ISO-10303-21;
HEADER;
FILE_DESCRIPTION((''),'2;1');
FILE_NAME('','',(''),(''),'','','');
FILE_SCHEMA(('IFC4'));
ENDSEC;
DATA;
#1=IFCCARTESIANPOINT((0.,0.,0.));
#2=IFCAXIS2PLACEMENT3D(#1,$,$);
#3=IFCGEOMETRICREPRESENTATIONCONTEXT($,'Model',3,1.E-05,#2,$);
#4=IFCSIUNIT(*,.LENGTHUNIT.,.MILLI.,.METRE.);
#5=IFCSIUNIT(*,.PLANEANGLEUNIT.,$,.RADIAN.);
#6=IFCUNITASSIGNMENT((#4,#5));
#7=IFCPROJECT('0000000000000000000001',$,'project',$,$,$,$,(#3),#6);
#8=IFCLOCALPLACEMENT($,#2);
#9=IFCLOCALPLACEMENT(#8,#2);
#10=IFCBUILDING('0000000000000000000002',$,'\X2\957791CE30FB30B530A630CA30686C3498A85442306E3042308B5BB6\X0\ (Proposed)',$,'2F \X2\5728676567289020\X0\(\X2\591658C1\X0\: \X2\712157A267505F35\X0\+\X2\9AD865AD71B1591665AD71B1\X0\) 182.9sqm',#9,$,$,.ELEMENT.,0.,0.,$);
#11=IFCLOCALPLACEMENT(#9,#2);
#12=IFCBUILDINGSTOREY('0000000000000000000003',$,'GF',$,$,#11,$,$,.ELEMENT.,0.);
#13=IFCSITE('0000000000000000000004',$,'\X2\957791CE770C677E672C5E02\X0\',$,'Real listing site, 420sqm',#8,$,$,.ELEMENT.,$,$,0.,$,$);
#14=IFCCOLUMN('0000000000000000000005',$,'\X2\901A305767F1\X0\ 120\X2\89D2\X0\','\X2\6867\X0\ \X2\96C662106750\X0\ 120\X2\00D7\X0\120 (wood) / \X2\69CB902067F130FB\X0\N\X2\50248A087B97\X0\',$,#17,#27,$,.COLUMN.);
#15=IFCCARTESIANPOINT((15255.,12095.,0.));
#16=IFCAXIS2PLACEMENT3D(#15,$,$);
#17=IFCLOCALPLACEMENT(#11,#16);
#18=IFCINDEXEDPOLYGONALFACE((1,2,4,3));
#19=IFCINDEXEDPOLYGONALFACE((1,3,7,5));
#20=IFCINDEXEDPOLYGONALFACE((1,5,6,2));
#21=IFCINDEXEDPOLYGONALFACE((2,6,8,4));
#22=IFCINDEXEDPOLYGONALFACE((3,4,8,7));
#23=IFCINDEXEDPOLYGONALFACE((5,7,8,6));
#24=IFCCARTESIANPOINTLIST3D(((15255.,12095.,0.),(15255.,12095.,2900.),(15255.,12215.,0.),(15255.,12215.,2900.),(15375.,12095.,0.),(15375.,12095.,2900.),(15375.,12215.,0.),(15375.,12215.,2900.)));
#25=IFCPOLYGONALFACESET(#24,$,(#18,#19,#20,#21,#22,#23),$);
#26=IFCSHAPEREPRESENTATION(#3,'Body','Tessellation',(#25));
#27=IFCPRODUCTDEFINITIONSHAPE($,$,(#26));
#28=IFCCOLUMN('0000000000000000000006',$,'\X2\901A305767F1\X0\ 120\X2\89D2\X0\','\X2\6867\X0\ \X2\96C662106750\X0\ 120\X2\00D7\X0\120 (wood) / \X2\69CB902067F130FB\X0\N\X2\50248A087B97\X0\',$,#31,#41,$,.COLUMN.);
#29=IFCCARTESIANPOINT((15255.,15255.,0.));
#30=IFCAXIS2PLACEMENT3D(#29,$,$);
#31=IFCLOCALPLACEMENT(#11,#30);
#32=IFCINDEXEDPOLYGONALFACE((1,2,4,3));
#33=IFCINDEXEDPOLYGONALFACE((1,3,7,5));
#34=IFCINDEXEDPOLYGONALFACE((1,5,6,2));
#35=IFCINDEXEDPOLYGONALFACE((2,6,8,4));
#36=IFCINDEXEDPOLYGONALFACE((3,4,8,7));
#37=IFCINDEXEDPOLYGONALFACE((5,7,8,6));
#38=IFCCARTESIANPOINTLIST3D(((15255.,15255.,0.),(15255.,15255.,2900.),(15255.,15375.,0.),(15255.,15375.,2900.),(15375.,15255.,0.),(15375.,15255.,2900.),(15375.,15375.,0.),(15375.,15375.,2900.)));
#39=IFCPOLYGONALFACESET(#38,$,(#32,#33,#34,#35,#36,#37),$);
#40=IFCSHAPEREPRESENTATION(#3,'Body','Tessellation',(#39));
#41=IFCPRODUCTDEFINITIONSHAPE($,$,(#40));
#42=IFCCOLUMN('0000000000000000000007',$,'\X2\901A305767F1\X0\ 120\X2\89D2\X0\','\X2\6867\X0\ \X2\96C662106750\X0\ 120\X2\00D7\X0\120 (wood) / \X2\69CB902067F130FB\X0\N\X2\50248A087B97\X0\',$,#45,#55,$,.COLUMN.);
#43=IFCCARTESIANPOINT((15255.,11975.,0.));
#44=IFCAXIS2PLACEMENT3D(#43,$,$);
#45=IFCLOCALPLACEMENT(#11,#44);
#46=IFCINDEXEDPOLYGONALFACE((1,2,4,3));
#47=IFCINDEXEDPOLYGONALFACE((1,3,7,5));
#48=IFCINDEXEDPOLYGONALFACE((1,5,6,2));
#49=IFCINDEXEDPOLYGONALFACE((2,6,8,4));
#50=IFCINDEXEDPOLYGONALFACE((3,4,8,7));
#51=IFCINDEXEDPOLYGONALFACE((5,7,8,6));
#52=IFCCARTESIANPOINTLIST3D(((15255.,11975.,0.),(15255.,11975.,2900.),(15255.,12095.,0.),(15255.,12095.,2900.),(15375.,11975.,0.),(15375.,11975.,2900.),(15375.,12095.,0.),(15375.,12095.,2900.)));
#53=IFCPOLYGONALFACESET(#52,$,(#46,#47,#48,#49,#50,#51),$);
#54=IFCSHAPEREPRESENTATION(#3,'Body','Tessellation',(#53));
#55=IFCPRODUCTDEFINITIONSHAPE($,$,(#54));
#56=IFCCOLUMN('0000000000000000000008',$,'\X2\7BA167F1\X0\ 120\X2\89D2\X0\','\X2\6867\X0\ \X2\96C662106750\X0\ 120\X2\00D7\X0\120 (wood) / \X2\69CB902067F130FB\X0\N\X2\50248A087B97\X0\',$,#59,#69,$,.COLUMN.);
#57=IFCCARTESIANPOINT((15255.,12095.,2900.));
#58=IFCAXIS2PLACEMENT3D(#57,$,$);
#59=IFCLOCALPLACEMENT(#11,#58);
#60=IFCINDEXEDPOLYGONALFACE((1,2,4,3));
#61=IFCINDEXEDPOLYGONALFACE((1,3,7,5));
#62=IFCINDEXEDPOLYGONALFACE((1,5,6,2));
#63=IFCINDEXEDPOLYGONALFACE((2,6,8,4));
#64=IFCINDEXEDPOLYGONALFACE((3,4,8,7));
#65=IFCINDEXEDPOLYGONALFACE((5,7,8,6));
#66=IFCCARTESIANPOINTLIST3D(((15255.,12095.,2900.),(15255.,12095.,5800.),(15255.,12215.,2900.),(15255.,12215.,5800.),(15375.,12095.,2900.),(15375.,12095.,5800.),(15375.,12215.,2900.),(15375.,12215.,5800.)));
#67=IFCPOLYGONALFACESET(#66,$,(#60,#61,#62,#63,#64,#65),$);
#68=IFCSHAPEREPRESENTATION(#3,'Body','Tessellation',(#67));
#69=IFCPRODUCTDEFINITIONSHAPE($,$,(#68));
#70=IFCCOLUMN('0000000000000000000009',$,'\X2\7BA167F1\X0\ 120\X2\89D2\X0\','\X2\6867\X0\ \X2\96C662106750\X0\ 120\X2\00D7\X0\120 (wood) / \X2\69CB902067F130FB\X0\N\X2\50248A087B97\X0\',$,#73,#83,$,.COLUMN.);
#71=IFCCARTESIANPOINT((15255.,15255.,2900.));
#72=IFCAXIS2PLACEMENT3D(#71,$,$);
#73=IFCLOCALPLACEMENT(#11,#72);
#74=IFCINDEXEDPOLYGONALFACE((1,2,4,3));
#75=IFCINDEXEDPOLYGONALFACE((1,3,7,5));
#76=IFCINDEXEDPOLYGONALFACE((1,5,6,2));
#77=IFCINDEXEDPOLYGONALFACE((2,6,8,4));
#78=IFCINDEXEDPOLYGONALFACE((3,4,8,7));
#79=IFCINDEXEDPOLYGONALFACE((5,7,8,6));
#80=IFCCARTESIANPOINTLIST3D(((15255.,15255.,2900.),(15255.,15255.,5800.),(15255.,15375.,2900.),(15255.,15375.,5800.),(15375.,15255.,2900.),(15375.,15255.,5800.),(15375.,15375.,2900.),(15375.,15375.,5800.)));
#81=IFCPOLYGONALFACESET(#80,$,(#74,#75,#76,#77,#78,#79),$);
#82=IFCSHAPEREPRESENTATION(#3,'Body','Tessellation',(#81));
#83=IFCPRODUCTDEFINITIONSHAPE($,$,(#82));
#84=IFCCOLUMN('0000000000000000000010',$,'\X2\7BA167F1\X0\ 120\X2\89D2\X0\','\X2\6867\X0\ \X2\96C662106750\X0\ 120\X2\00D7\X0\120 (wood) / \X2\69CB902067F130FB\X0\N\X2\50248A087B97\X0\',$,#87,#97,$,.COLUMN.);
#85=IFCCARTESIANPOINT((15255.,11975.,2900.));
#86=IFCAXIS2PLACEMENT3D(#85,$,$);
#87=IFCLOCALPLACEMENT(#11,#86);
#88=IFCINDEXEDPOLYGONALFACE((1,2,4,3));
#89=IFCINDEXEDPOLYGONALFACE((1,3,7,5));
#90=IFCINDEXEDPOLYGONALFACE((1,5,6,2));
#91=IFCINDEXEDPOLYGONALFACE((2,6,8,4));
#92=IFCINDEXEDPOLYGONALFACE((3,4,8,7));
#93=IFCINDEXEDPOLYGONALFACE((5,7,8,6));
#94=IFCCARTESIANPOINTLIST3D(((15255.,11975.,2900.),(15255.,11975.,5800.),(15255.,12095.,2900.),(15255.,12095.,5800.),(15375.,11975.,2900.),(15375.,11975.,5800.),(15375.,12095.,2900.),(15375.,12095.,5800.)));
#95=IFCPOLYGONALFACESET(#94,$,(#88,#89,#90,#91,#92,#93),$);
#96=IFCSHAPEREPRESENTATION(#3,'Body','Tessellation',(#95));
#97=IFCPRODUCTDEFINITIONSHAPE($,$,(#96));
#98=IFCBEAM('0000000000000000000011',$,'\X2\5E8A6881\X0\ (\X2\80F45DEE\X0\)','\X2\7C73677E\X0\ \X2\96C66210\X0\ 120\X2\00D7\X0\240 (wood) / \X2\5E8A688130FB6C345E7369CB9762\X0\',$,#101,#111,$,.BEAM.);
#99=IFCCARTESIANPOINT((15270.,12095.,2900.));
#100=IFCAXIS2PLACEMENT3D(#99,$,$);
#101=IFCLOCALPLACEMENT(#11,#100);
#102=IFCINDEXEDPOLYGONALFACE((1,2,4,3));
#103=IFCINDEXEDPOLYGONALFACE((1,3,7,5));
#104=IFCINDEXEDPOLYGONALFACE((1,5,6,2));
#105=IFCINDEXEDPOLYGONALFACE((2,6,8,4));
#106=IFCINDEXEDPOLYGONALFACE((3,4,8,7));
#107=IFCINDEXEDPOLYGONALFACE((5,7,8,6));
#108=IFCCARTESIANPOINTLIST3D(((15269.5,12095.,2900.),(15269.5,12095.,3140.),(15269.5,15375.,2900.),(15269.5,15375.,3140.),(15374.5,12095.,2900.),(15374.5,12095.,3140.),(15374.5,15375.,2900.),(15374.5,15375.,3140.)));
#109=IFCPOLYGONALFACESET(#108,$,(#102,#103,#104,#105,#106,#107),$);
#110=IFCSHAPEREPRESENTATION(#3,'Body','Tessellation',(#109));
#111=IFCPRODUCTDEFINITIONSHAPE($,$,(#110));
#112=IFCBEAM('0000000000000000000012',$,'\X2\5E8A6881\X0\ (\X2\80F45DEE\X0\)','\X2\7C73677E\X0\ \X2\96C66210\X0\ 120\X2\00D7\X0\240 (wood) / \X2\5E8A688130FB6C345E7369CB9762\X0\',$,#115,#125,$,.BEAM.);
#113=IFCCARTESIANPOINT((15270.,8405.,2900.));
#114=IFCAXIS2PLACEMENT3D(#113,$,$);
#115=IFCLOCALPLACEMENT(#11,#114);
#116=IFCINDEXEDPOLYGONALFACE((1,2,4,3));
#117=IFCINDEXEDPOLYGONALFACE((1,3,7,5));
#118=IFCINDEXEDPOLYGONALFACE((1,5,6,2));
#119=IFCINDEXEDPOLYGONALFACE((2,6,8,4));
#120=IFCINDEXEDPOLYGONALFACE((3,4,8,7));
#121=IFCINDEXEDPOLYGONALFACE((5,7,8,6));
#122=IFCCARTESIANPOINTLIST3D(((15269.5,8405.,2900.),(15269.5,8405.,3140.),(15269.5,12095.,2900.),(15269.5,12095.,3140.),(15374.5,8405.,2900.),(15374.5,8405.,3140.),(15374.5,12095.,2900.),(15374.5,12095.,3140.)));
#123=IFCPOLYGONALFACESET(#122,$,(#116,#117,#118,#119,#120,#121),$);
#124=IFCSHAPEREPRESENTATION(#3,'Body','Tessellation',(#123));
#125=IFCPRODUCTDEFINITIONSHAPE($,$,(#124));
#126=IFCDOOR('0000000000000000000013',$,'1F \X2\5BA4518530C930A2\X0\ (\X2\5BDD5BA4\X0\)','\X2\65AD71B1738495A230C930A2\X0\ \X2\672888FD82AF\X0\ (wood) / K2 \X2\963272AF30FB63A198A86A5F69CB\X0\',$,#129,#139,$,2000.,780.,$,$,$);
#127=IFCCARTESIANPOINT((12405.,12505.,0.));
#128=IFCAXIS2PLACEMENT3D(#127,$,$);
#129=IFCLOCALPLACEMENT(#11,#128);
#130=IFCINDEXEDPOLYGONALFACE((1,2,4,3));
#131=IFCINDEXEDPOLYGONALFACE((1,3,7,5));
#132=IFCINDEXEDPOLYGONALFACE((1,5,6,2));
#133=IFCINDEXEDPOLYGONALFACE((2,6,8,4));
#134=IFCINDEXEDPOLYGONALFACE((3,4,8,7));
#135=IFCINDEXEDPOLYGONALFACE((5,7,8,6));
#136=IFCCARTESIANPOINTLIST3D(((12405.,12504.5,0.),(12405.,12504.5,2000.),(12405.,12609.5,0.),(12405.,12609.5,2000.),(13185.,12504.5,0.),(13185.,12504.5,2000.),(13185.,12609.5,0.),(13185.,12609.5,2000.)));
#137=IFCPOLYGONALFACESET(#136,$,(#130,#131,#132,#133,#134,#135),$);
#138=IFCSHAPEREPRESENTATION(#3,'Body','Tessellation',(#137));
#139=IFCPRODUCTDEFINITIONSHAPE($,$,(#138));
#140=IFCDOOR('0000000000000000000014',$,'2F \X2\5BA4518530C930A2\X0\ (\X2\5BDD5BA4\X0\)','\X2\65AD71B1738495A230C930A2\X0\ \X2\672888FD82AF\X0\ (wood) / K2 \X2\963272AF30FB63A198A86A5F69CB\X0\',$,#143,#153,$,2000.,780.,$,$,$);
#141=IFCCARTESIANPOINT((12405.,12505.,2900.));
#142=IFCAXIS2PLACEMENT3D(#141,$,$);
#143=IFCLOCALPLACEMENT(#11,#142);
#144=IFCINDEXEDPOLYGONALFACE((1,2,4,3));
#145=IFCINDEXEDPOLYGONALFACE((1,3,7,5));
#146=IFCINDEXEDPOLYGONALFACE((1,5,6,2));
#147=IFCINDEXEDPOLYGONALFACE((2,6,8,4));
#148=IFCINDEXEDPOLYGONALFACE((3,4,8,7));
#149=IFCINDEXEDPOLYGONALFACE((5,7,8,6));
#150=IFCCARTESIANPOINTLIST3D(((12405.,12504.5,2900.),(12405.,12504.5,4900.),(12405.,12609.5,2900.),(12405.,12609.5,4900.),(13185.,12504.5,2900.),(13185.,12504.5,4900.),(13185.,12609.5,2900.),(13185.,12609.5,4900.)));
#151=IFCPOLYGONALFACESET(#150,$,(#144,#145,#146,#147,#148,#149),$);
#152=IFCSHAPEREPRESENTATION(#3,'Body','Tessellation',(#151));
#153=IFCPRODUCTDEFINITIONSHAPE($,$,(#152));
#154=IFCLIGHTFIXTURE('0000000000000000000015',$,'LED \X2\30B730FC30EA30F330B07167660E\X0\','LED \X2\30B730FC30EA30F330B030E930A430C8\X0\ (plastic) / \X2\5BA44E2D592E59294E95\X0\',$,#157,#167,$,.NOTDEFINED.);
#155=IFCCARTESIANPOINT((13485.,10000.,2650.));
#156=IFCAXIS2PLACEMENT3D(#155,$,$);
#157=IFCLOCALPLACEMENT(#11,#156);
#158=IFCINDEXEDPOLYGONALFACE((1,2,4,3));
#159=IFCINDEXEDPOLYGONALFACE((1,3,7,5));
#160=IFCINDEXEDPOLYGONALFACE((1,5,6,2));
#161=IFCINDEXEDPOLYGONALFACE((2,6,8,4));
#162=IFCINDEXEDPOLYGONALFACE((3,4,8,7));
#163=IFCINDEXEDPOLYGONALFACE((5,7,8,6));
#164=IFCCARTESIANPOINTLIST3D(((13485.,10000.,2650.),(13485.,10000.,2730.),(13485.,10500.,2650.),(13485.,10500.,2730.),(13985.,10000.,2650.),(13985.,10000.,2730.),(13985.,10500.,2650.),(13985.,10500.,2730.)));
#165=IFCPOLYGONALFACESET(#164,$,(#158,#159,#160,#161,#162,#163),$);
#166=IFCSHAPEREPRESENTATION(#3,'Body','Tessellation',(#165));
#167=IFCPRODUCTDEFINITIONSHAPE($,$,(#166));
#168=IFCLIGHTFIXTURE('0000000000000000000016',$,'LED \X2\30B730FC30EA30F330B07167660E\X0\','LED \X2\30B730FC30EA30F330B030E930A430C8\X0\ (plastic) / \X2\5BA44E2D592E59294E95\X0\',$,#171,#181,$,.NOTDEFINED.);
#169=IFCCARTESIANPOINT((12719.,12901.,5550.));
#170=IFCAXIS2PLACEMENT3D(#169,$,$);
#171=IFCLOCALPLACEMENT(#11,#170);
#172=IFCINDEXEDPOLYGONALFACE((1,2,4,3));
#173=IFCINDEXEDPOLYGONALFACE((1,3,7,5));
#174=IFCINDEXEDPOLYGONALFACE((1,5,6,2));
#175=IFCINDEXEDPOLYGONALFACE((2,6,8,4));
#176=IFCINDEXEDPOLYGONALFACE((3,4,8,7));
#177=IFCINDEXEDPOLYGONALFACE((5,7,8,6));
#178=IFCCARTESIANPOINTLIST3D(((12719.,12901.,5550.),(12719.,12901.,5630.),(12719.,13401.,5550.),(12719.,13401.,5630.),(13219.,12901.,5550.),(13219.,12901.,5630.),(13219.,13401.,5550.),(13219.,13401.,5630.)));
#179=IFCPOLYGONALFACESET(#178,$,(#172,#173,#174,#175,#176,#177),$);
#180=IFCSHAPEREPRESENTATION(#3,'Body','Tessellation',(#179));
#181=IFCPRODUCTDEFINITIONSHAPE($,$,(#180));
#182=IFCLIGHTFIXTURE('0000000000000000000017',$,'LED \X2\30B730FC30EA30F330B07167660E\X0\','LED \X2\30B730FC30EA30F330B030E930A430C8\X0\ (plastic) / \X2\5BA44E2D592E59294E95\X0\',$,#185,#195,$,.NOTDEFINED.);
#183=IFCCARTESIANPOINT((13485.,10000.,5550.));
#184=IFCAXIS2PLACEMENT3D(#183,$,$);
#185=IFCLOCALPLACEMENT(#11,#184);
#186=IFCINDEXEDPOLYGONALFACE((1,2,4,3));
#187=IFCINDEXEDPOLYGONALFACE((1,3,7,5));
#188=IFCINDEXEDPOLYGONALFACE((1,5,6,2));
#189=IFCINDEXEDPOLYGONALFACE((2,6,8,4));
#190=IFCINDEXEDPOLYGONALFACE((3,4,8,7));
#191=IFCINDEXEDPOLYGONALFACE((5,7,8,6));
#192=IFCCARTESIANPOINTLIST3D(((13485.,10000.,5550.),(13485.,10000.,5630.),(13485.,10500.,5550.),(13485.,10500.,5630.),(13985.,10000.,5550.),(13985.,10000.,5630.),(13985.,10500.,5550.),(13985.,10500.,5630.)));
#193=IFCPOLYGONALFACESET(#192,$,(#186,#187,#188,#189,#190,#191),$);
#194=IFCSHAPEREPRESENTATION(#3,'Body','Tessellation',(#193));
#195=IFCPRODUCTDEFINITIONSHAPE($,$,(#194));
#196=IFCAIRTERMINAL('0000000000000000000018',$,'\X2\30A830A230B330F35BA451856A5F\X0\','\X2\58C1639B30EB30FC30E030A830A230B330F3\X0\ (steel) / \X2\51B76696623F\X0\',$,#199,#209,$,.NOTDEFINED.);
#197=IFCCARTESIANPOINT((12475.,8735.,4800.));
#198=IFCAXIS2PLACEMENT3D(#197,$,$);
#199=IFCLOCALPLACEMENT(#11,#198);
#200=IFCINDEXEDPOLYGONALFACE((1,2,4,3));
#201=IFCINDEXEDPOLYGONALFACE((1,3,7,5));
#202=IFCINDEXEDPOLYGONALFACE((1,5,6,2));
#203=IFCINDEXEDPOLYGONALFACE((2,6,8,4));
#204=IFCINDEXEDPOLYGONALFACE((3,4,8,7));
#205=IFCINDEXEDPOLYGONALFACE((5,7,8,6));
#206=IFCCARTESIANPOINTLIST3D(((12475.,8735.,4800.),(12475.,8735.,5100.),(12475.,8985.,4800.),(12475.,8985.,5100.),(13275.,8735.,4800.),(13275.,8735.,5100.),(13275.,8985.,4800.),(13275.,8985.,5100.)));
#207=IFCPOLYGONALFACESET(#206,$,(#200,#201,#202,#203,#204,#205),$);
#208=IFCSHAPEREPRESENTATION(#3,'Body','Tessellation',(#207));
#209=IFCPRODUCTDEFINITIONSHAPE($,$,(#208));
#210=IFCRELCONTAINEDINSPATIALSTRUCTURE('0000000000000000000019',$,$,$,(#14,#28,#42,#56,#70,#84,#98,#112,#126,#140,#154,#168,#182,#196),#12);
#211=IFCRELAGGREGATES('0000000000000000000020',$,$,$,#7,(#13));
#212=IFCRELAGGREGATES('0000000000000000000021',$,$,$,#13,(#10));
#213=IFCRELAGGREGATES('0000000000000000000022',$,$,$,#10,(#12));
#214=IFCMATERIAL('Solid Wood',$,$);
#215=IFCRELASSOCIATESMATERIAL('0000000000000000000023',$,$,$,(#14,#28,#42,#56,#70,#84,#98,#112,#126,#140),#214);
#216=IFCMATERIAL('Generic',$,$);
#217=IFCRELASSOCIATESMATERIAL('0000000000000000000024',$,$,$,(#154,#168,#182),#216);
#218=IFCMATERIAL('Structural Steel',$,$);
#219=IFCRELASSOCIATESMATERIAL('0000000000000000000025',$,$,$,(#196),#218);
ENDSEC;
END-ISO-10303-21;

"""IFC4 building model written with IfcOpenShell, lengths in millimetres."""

from ifc_helpers import new_model, si_unit, frame, frame_2d, origin, place, context, project, spatial, rectangle, extrude, material, element, save


model = new_model("IFC4")

# Units and contexts
model_context = context("Model", 3, precision=1e-05, world=origin())
ifc_project = project(units=[si_unit("LENGTHUNIT", "METRE", prefix="MILLI"), si_unit("PLANEANGLEUNIT", "RADIAN")], contexts=[model_context])

# Site, building, storey
site_placement = place(None, origin())
site = spatial("IfcSite", under=ifc_project, at=site_placement, Name="長野県松本市", ObjectType="Real listing site, 420sqm", CompositionType="ELEMENT", RefElevation=0.0)
building_placement = place(site_placement, origin())
building = spatial("IfcBuilding", under=site, at=building_placement, Name="長野・サウナと水風呂のある家 (Proposed)", ObjectType="2F 在来木造(外壁: 無垢材張+高断熱外断熱) 182.9sqm", CompositionType="ELEMENT", ElevationOfRefHeight=0.0, ElevationOfTerrain=0.0)
storey_placement = place(building_placement, origin())
storey = spatial("IfcBuildingStorey", under=building, at=storey_placement, Name="GF", CompositionType="ELEMENT", Elevation=0.0)

# Columns
ifc_material_1 = material(Name="Solid Wood")
column_1_placement = place(storey_placement, frame((15255.0, 12095.0, 0.0)))
element("IfcColumn", 1, at=column_1_placement, inside=storey, material=ifc_material_1, Name="通し柱 120角", Description="桧 集成材 120×120 (wood) / 構造柱・N値計算", PredefinedType="COLUMN", context=model_context, shape_type="SweptSolid", body=[
    extrude(rectangle(XDim=120.0, YDim=120.0, at=frame_2d((60.0, 60.0))), frame((15255.0, 12095.0, 0.0)), (0.0, 0.0, 1.0), 2900.0),
])
column_2_placement = place(storey_placement, frame((15255.0, 15255.0, 0.0)))
element("IfcColumn", 2, at=column_2_placement, inside=storey, material=ifc_material_1, Name="通し柱 120角", Description="桧 集成材 120×120 (wood) / 構造柱・N値計算", PredefinedType="COLUMN", context=model_context, shape_type="SweptSolid", body=[
    extrude(rectangle(XDim=120.0, YDim=120.0, at=frame_2d((60.0, 60.0))), frame((15255.0, 15255.0, 0.0)), (0.0, 0.0, 1.0), 2900.0),
])
column_3_placement = place(storey_placement, frame((15255.0, 11975.0, 0.0)))
element("IfcColumn", 3, at=column_3_placement, inside=storey, material=ifc_material_1, Name="通し柱 120角", Description="桧 集成材 120×120 (wood) / 構造柱・N値計算", PredefinedType="COLUMN", context=model_context, shape_type="SweptSolid", body=[
    extrude(rectangle(XDim=120.0, YDim=120.0, at=frame_2d((60.0, 60.0))), frame((15255.0, 11975.0, 0.0)), (0.0, 0.0, 1.0), 2900.0),
])
column_4_placement = place(storey_placement, frame((15255.0, 12095.0, 2900.0)))
element("IfcColumn", 4, at=column_4_placement, inside=storey, material=ifc_material_1, Name="管柱 120角", Description="桧 集成材 120×120 (wood) / 構造柱・N値計算", PredefinedType="COLUMN", context=model_context, shape_type="SweptSolid", body=[
    extrude(rectangle(XDim=120.0, YDim=120.0, at=frame_2d((60.0, 60.0))), frame((15255.0, 12095.0, 2900.0)), (0.0, 0.0, 1.0), 2900.0),
])
column_5_placement = place(storey_placement, frame((15255.0, 15255.0, 2900.0)))
element("IfcColumn", 5, at=column_5_placement, inside=storey, material=ifc_material_1, Name="管柱 120角", Description="桧 集成材 120×120 (wood) / 構造柱・N値計算", PredefinedType="COLUMN", context=model_context, shape_type="SweptSolid", body=[
    extrude(rectangle(XDim=120.0, YDim=120.0, at=frame_2d((60.0, 60.0))), frame((15255.0, 15255.0, 2900.0)), (0.0, 0.0, 1.0), 2900.0),
])
column_6_placement = place(storey_placement, frame((15255.0, 11975.0, 2900.0)))
element("IfcColumn", 6, at=column_6_placement, inside=storey, material=ifc_material_1, Name="管柱 120角", Description="桧 集成材 120×120 (wood) / 構造柱・N値計算", PredefinedType="COLUMN", context=model_context, shape_type="SweptSolid", body=[
    extrude(rectangle(XDim=120.0, YDim=120.0, at=frame_2d((60.0, 60.0))), frame((15255.0, 11975.0, 2900.0)), (0.0, 0.0, 1.0), 2900.0),
])

# Beams
beam_1_placement = place(storey_placement, frame((15270.0, 12095.0, 2900.0)))
element("IfcBeam", 7, at=beam_1_placement, inside=storey, material=ifc_material_1, Name="床梁 (胴差)", Description="米松 集成 120×240 (wood) / 床梁・水平構面", PredefinedType="BEAM", context=model_context, shape_type="SweptSolid", body=[
    extrude(rectangle(XDim=105.0, YDim=3280.0, at=frame_2d((52.0, 1640.0))), frame((15270.0, 12095.0, 2900.0)), (0.0, 0.0, 1.0), 240.0),
])
beam_2_placement = place(storey_placement, frame((15270.0, 8405.0, 2900.0)))
element("IfcBeam", 8, at=beam_2_placement, inside=storey, material=ifc_material_1, Name="床梁 (胴差)", Description="米松 集成 120×240 (wood) / 床梁・水平構面", PredefinedType="BEAM", context=model_context, shape_type="SweptSolid", body=[
    extrude(rectangle(XDim=105.0, YDim=3690.0, at=frame_2d((52.0, 1845.0))), frame((15270.0, 8405.0, 2900.0)), (0.0, 0.0, 1.0), 240.0),
])

# Doors
door_1_placement = place(storey_placement, frame((12405.0, 12505.0, 0.0)))
element("IfcDoor", 9, at=door_1_placement, inside=storey, material=ifc_material_1, Name="1F 室内ドア (寝室)", Description="断熱玄関ドア 木製芯 (wood) / K2 防犯・採風機構", OverallHeight=2000.0, OverallWidth=780.0, context=model_context, shape_type="SweptSolid", body=[
    extrude(rectangle(XDim=780.0, YDim=105.0, at=frame_2d((390.0, 52.0))), frame((12405.0, 12505.0, 0.0)), (0.0, 0.0, 1.0), 2000.0),
])
door_2_placement = place(storey_placement, frame((12405.0, 12505.0, 2900.0)))
element("IfcDoor", 10, at=door_2_placement, inside=storey, material=ifc_material_1, Name="2F 室内ドア (寝室)", Description="断熱玄関ドア 木製芯 (wood) / K2 防犯・採風機構", OverallHeight=2000.0, OverallWidth=780.0, context=model_context, shape_type="SweptSolid", body=[
    extrude(rectangle(XDim=780.0, YDim=105.0, at=frame_2d((390.0, 52.0))), frame((12405.0, 12505.0, 2900.0)), (0.0, 0.0, 1.0), 2000.0),
])

# Light fixtures
ifc_material_2 = material(Name="Generic")
light_fixture_1_placement = place(storey_placement, frame((13485.0, 10000.0, 2650.0)))
element("IfcLightFixture", 11, at=light_fixture_1_placement, inside=storey, material=ifc_material_2, Name="LED シーリング照明", Description="LED シーリングライト (plastic) / 室中央天井", PredefinedType="NOTDEFINED", context=model_context, shape_type="SweptSolid", body=[
    extrude(rectangle(XDim=500.0, YDim=500.0, at=frame_2d((250.0, 250.0))), frame((13485.0, 10000.0, 2650.0)), (0.0, 0.0, 1.0), 80.0),
])
light_fixture_2_placement = place(storey_placement, frame((12719.0, 12901.0, 5550.0)))
element("IfcLightFixture", 12, at=light_fixture_2_placement, inside=storey, material=ifc_material_2, Name="LED シーリング照明", Description="LED シーリングライト (plastic) / 室中央天井", PredefinedType="NOTDEFINED", context=model_context, shape_type="SweptSolid", body=[
    extrude(rectangle(XDim=500.0, YDim=500.0, at=frame_2d((250.0, 250.0))), frame((12719.0, 12901.0, 5550.0)), (0.0, 0.0, 1.0), 80.0),
])
light_fixture_3_placement = place(storey_placement, frame((13485.0, 10000.0, 5550.0)))
element("IfcLightFixture", 13, at=light_fixture_3_placement, inside=storey, material=ifc_material_2, Name="LED シーリング照明", Description="LED シーリングライト (plastic) / 室中央天井", PredefinedType="NOTDEFINED", context=model_context, shape_type="SweptSolid", body=[
    extrude(rectangle(XDim=500.0, YDim=500.0, at=frame_2d((250.0, 250.0))), frame((13485.0, 10000.0, 5550.0)), (0.0, 0.0, 1.0), 80.0),
])

# Air terminal
ifc_material_3 = material(Name="Structural Steel")
air_terminal_placement = place(storey_placement, frame((12475.0, 8735.0, 4800.0)))
element("IfcAirTerminal", 14, at=air_terminal_placement, inside=storey, material=ifc_material_3, Name="エアコン室内機", Description="壁掛ルームエアコン (steel) / 冷暖房", PredefinedType="NOTDEFINED", context=model_context, shape_type="SweptSolid", body=[
    extrude(rectangle(XDim=800.0, YDim=250.0, at=frame_2d((400.0, 125.0))), frame((12475.0, 8735.0, 4800.0)), (0.0, 0.0, 1.0), 300.0),
])

save(model, "model.ifc")
